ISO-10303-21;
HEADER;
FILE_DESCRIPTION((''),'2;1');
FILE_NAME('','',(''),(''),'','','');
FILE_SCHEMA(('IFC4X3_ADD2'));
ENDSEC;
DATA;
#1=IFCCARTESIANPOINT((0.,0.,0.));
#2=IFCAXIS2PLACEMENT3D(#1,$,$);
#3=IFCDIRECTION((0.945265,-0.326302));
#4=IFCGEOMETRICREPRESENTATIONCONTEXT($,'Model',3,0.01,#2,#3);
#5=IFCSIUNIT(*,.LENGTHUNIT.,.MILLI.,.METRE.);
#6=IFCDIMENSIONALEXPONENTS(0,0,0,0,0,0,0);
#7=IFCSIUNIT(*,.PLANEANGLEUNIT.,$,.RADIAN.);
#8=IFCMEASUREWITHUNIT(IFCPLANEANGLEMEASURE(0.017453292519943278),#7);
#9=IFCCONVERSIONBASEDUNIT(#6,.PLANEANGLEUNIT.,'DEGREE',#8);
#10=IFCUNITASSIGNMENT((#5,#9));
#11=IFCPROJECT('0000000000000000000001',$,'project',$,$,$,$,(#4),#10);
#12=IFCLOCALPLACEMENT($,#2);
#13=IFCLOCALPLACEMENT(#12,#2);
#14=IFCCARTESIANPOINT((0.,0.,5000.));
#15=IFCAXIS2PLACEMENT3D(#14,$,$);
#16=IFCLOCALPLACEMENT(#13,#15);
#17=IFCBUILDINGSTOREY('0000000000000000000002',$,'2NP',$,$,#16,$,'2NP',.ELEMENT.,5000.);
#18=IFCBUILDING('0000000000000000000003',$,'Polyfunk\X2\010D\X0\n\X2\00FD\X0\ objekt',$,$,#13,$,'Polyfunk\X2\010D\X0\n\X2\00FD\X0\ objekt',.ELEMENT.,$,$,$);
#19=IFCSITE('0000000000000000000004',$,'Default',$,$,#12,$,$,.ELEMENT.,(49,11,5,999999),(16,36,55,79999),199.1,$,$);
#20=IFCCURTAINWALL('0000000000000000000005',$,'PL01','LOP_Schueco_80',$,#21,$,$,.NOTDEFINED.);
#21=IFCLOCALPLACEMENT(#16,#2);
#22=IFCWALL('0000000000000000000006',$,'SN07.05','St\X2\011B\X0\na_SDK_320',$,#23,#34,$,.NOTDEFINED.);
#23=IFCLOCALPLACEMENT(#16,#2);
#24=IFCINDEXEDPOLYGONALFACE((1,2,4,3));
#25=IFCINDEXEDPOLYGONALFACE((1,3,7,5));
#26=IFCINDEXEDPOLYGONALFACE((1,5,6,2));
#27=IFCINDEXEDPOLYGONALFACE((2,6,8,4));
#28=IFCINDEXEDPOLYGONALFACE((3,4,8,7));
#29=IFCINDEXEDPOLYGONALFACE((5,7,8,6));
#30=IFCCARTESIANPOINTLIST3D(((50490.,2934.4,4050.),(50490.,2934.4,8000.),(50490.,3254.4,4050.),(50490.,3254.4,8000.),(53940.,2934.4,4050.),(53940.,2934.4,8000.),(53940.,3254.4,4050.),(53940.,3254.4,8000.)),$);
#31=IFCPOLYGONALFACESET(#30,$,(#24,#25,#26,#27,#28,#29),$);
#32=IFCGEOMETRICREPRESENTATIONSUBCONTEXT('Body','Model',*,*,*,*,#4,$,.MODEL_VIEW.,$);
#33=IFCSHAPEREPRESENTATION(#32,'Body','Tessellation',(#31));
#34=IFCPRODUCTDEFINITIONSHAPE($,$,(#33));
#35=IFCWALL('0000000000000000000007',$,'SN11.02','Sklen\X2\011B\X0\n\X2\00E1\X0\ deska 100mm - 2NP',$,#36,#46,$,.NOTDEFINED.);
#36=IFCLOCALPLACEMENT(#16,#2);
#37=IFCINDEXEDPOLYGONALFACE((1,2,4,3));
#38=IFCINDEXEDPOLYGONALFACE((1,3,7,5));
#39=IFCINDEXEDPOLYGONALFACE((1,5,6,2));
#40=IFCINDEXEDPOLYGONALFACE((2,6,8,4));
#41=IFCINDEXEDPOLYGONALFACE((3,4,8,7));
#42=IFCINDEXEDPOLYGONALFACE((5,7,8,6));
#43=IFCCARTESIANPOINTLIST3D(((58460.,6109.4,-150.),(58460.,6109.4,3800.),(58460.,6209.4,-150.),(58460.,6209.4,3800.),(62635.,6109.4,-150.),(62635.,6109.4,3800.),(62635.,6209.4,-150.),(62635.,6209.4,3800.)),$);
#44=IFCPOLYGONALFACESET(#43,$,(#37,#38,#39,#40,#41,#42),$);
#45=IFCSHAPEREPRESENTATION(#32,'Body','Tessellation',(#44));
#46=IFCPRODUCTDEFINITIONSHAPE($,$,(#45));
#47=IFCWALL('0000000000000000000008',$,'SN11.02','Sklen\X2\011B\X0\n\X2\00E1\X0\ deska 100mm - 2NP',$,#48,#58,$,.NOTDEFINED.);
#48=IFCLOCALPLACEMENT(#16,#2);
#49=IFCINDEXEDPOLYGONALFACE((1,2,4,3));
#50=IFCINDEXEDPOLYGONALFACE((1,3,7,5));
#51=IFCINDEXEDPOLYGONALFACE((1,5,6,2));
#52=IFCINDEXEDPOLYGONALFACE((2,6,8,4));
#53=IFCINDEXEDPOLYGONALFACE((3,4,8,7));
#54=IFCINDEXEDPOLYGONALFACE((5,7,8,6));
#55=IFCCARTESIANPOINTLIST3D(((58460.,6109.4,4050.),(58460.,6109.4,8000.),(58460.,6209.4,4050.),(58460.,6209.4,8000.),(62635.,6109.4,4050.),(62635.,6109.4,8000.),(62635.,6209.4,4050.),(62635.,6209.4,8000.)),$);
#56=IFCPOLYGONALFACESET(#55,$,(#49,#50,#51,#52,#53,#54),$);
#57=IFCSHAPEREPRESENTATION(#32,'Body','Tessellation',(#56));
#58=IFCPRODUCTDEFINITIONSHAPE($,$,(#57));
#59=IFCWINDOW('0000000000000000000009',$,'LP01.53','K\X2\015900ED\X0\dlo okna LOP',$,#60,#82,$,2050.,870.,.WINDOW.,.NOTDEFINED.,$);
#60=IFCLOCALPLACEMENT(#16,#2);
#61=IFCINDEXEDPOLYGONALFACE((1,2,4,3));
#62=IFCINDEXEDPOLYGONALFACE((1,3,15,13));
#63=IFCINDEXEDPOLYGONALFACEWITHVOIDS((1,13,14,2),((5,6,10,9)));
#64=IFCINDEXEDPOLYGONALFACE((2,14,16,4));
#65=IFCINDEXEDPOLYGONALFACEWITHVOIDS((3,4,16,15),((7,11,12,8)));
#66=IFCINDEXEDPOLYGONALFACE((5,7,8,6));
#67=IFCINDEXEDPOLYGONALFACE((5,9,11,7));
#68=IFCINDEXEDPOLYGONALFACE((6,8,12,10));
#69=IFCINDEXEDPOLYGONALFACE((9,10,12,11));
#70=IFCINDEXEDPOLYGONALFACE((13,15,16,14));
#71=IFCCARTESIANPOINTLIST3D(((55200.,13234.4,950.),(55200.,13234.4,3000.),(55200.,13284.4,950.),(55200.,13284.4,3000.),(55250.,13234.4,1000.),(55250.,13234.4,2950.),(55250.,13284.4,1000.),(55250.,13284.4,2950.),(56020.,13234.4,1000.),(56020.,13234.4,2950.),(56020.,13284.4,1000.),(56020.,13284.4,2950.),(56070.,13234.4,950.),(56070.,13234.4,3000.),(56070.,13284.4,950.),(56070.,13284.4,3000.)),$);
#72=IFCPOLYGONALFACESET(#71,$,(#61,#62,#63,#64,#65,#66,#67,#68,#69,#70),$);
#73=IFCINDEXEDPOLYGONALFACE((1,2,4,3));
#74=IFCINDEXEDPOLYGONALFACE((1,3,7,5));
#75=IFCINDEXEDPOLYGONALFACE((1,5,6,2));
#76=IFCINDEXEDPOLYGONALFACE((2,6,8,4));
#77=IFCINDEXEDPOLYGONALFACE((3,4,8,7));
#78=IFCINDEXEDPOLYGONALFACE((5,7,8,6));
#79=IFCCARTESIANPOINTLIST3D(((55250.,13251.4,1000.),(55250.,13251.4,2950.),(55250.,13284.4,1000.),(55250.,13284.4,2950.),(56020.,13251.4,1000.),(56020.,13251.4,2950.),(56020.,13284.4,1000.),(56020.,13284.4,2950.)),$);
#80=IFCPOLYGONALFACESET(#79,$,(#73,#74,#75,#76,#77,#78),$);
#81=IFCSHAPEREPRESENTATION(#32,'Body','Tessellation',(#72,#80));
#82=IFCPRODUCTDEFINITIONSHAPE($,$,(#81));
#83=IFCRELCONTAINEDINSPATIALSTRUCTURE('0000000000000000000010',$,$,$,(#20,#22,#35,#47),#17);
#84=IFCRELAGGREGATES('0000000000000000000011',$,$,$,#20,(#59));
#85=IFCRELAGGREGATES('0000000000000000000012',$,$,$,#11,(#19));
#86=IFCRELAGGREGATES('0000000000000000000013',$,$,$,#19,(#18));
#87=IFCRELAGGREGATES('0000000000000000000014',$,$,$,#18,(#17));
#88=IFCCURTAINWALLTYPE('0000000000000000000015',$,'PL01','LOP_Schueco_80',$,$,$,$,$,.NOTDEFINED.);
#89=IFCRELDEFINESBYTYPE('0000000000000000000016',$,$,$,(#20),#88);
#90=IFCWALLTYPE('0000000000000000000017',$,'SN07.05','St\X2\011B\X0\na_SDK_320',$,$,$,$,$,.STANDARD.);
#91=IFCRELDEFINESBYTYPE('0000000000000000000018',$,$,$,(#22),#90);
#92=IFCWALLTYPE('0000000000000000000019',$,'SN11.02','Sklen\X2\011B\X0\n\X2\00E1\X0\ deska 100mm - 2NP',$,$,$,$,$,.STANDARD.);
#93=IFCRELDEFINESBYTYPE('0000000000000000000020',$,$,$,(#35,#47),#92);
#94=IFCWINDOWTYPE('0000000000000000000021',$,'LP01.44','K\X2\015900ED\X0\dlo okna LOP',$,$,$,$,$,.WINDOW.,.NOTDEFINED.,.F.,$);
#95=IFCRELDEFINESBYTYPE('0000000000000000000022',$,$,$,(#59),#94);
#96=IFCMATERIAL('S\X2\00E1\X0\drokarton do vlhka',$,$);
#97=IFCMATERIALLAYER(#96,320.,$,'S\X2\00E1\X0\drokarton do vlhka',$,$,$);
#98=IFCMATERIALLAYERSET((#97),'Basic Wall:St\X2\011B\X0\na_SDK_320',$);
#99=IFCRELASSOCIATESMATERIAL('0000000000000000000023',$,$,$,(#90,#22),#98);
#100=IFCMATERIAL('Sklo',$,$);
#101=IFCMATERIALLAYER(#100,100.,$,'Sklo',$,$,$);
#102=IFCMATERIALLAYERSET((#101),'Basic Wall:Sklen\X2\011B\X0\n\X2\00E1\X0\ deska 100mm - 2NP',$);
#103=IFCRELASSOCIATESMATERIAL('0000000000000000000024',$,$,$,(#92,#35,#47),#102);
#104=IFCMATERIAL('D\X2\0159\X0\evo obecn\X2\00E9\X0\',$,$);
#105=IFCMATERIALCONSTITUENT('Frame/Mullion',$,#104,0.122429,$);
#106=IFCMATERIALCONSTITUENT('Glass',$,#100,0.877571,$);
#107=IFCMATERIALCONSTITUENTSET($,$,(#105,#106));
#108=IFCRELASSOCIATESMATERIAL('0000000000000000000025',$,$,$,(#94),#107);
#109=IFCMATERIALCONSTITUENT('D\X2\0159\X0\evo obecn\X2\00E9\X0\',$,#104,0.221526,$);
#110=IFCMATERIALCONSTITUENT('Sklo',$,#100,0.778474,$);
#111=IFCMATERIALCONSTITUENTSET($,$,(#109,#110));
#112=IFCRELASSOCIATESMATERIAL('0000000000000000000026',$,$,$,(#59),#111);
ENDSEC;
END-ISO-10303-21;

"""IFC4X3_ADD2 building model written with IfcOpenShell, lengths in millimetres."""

from ifc_helpers import new_model, entity, si_unit, converted_unit, direction, frame, frame_2d, origin, origin_2d_with_axis, place, context, subcontext, project, spatial, polyline, rectangle, outline, extrude, clip, bounded_halfspace, source, transform, mapped, material, layer, layer_set, constituent, constituent_set, type_object, type_shapes, element, aggregate, save


model = new_model("IFC4X3_ADD2")

# Units and contexts
model_context = context("Model", 3, precision=0.01, world=origin(), true_north=direction((0.945265, -0.326302)))
body_context = subcontext(model_context, "Body", "Model", "MODEL_VIEW")
ifc_project = project(units=[si_unit("LENGTHUNIT", "METRE", prefix="MILLI"), converted_unit("PLANEANGLEUNIT", "DEGREE", entity("IfcPlaneAngleMeasure", 0.017453292519943278), si_unit("PLANEANGLEUNIT", "RADIAN"), dimensions=[0, 0, 0, 0, 0, 0, 0])], contexts=[model_context])

# Site, building, storey
site_placement = place(None, origin())
site = spatial("IfcSite", under=ifc_project, at=site_placement, Name="Default", CompositionType="ELEMENT", RefLatitude=(49, 11, 5, 999999), RefLongitude=(16, 36, 55, 79999), RefElevation=199.1)
building_placement = place(site_placement, origin())
building = spatial("IfcBuilding", under=site, at=building_placement, Name="Polyfunkčný objekt", LongName="Polyfunkčný objekt", CompositionType="ELEMENT")
storey_placement = place(building_placement, frame((0.0, 0.0, 5000.0)))
storey = spatial("IfcBuildingStorey", under=building, at=storey_placement, Name="2NP", LongName="2NP", CompositionType="ELEMENT", Elevation=5000.0)

# Curtain wall
curtain_wall_type = type_object("IfcCurtainWallType", Name="PL01", Description="LOP_Schueco_80", PredefinedType="NOTDEFINED")
curtain_wall_placement = place(storey_placement, frame((0.0, 0.0, -5000.0)))
curtain_wall = element("IfcCurtainWall", 1, at=curtain_wall_placement, inside=storey, type_object=curtain_wall_type, Name="PL01", Description="LOP_Schueco_80", PredefinedType="NOTDEFINED")
ifc_material_1 = material(Name="Sklo")

# Walls
ifc_material_2 = material(Name="Sádrokarton do vlhka")
ifc_layer_1 = layer(ifc_material_2, 320.0, Name="Sádrokarton do vlhka")
ifc_layer_set_1 = layer_set([ifc_layer_1], Name="Basic Wall:Stěna_SDK_320")
wall_type_1 = type_object("IfcWallType", Name="SN07.05", Description="Stěna_SDK_320", PredefinedType="STANDARD", material=ifc_layer_set_1)
wall_1_placement = place(storey_placement, frame((53940.0, 3094.4, 4050.0), z_axis=(0.0, 0.0, 1.0), x_axis=(-1.0, 0.0, 0.0)))
element("IfcWall", 2, at=wall_1_placement, inside=storey, type_object=wall_type_1, material=ifc_layer_set_1, Name="SN07.05", Description="Stěna_SDK_320", PredefinedType="NOTDEFINED", context=body_context, shape_type="Clipping", body=[
    clip(clip(extrude(rectangle(XDim=3450.0, YDim=320.0, at=frame_2d((1725.0, 0.0), x_axis=(-1.0, 0.0))), origin(), (0.0, 0.0, 1.0), 3950.0), bounded_halfspace(frame((3450.0, -160.0, 0.0)), True, frame((3450.0, -160.0, 0.0)), polyline([(0.0, 0.0), (0.0, 320.0), (-1650.0, 320.0), (-1800.0, 320.0), (-3450.0, 320.0), (-3450.0, 0.0), (-1800.0, 0.0), (-1650.0, 0.0), (0.0, 0.0)]))), bounded_halfspace(frame((0.0, -160.0, 3950.0), z_axis=(0.0, 0.0, -1.0), x_axis=(-1.0, 0.0, 0.0)), True, frame((0.0, -160.0, 3950.0)), polyline([(0.0, 0.0), (1650.0, 0.0), (1800.0, 0.0), (3450.0, 0.0), (3450.0, 320.0), (1800.0, 320.0), (1650.0, 320.0), (0.0, 320.0), (0.0, 0.0)]))),
])
ifc_layer_2 = layer(ifc_material_1, 100.0, Name="Sklo")
ifc_layer_set_2 = layer_set([ifc_layer_2], Name="Basic Wall:Skleněná deska 100mm - 2NP")
wall_type_2 = type_object("IfcWallType", Name="SN11.02", Description="Skleněná deska 100mm - 2NP", PredefinedType="STANDARD", material=ifc_layer_set_2)
wall_2_placement = place(storey_placement, frame((58460.0, 6159.4, -150.0)))
element("IfcWall", 3, at=wall_2_placement, inside=storey, type_object=wall_type_2, material=ifc_layer_set_2, Name="SN11.02", Description="Skleněná deska 100mm - 2NP", PredefinedType="NOTDEFINED", context=body_context, shape_type="Clipping", body=[
    clip(clip(extrude(rectangle(XDim=4175.0, YDim=100.0, at=frame_2d((2087.5, 0.0), x_axis=(-1.0, 0.0))), origin(), (0.0, 0.0, 1.0), 3950.0), bounded_halfspace(frame((4175.0, -50.0, 0.0), z_axis=(0.0, 0.0, 1.0), x_axis=(-1.0, 0.0, 0.0)), True, frame((4175.0, -50.0, 0.0)), polyline([(0.0, 0.0), (0.0, 100.0), (-4175.0, 100.0), (-4175.0, 0.0), (-4075.0, 0.0), (0.0, 0.0)]))), bounded_halfspace(frame((0.0, -50.0, 3950.0), z_axis=(0.0, 0.0, -1.0), x_axis=(1.0, 0.0, 0.0)), True, frame((0.0, -50.0, 3950.0)), polyline([(0.0, 0.0), (100.0, 0.0), (4175.0, 0.0), (4175.0, 100.0), (0.0, 100.0), (0.0, 0.0)]))),
])
wall_3_placement = place(storey_placement, frame((58460.0, 6159.4, 4050.0)))
element("IfcWall", 4, at=wall_3_placement, inside=storey, type_object=wall_type_2, material=ifc_layer_set_2, Name="SN11.02", Description="Skleněná deska 100mm - 2NP", PredefinedType="NOTDEFINED", context=body_context, shape_type="Clipping", body=[
    clip(clip(extrude(rectangle(XDim=4175.0, YDim=100.0, at=frame_2d((2087.5, 0.0), x_axis=(-1.0, 0.0))), origin(), (0.0, 0.0, 1.0), 3950.0), bounded_halfspace(frame((4175.0, -50.0, 0.0), z_axis=(0.0, 0.0, 1.0), x_axis=(-1.0, 0.0, 0.0)), True, frame((4175.0, -50.0, 0.0)), polyline([(0.0, 0.0), (0.0, 100.0), (-4175.0, 100.0), (-4175.0, 0.0), (-4075.0, 0.0), (0.0, 0.0)]))), bounded_halfspace(frame((0.0, -50.0, 3950.0), z_axis=(0.0, 0.0, -1.0), x_axis=(1.0, 0.0, 0.0)), True, frame((0.0, -50.0, 3950.0)), polyline([(0.0, 0.0), (100.0, 0.0), (4175.0, 0.0), (4175.0, 100.0), (0.0, 100.0), (0.0, 0.0)]))),
])

# Window
ifc_material_3 = material(Name="Dřevo obecné")
ifc_constituent_1 = constituent(ifc_material_3, Name="Dřevo obecné", fraction=0.221526)
ifc_constituent_2 = constituent(ifc_material_1, Name="Sklo", fraction=0.778474)
ifc_constituent_set_1 = constituent_set(constituents=[ifc_constituent_1, ifc_constituent_2])
ifc_constituent_3 = constituent(ifc_material_3, Name="Frame/Mullion", fraction=0.122429)
ifc_constituent_4 = constituent(ifc_material_1, Name="Glass", fraction=0.877571)
ifc_constituent_set_2 = constituent_set(constituents=[ifc_constituent_3, ifc_constituent_4])
window_type = type_object("IfcWindowType", Name="LP01.44", Description="Křídlo okna LOP", ParameterTakesPrecedence=False, PartitioningType="NOTDEFINED", PredefinedType="WINDOW", material=ifc_constituent_set_2)
shared_shape_1 = source(origin(), body_context, "Body", "SweptSolid", [
    extrude(outline(polyline([(-1025.0, -435.0), (1025.0, -435.0), (1025.0, 435.0), (-1025.0, 435.0), (-1025.0, -435.0)]), holes=[polyline([(-975.0, -385.0), (-975.0, 385.0), (975.0, 385.0), (975.0, -385.0), (-975.0, -385.0)])]), frame((0.0, 0.0, 1025.0), z_axis=(0.0, 1.0, 0.0), x_axis=(0.0, 0.0, -1.0)), (0.0, 0.0, 1.0), 50.0),
    extrude(rectangle(XDim=33.0, YDim=770.0, at=origin_2d_with_axis()), frame((0.0, 33.5, 50.0), z_axis=(0.0, 0.0, 1.0), x_axis=(0.0, -1.0, 0.0)), (0.0, 0.0, 1.0), 1950.0),
])
type_shapes(window_type, [shared_shape_1])
window_placement = place(curtain_wall_placement, frame((55635.0, 13234.4, 5950.0)))
window = element("IfcWindow", 5, at=window_placement, type_object=window_type, material=ifc_constituent_set_1, Name="LP01.53", Description="Křídlo okna LOP", OverallHeight=2050.0, OverallWidth=870.0, PartitioningType="NOTDEFINED", PredefinedType="WINDOW", context=body_context, shape_type="MappedRepresentation", body=[
    mapped(shared_shape_1, transform((0.0, 0.0, 0.0), scale=1.0)),
])
aggregate(curtain_wall, [window])

save(model, "model.ifc")
